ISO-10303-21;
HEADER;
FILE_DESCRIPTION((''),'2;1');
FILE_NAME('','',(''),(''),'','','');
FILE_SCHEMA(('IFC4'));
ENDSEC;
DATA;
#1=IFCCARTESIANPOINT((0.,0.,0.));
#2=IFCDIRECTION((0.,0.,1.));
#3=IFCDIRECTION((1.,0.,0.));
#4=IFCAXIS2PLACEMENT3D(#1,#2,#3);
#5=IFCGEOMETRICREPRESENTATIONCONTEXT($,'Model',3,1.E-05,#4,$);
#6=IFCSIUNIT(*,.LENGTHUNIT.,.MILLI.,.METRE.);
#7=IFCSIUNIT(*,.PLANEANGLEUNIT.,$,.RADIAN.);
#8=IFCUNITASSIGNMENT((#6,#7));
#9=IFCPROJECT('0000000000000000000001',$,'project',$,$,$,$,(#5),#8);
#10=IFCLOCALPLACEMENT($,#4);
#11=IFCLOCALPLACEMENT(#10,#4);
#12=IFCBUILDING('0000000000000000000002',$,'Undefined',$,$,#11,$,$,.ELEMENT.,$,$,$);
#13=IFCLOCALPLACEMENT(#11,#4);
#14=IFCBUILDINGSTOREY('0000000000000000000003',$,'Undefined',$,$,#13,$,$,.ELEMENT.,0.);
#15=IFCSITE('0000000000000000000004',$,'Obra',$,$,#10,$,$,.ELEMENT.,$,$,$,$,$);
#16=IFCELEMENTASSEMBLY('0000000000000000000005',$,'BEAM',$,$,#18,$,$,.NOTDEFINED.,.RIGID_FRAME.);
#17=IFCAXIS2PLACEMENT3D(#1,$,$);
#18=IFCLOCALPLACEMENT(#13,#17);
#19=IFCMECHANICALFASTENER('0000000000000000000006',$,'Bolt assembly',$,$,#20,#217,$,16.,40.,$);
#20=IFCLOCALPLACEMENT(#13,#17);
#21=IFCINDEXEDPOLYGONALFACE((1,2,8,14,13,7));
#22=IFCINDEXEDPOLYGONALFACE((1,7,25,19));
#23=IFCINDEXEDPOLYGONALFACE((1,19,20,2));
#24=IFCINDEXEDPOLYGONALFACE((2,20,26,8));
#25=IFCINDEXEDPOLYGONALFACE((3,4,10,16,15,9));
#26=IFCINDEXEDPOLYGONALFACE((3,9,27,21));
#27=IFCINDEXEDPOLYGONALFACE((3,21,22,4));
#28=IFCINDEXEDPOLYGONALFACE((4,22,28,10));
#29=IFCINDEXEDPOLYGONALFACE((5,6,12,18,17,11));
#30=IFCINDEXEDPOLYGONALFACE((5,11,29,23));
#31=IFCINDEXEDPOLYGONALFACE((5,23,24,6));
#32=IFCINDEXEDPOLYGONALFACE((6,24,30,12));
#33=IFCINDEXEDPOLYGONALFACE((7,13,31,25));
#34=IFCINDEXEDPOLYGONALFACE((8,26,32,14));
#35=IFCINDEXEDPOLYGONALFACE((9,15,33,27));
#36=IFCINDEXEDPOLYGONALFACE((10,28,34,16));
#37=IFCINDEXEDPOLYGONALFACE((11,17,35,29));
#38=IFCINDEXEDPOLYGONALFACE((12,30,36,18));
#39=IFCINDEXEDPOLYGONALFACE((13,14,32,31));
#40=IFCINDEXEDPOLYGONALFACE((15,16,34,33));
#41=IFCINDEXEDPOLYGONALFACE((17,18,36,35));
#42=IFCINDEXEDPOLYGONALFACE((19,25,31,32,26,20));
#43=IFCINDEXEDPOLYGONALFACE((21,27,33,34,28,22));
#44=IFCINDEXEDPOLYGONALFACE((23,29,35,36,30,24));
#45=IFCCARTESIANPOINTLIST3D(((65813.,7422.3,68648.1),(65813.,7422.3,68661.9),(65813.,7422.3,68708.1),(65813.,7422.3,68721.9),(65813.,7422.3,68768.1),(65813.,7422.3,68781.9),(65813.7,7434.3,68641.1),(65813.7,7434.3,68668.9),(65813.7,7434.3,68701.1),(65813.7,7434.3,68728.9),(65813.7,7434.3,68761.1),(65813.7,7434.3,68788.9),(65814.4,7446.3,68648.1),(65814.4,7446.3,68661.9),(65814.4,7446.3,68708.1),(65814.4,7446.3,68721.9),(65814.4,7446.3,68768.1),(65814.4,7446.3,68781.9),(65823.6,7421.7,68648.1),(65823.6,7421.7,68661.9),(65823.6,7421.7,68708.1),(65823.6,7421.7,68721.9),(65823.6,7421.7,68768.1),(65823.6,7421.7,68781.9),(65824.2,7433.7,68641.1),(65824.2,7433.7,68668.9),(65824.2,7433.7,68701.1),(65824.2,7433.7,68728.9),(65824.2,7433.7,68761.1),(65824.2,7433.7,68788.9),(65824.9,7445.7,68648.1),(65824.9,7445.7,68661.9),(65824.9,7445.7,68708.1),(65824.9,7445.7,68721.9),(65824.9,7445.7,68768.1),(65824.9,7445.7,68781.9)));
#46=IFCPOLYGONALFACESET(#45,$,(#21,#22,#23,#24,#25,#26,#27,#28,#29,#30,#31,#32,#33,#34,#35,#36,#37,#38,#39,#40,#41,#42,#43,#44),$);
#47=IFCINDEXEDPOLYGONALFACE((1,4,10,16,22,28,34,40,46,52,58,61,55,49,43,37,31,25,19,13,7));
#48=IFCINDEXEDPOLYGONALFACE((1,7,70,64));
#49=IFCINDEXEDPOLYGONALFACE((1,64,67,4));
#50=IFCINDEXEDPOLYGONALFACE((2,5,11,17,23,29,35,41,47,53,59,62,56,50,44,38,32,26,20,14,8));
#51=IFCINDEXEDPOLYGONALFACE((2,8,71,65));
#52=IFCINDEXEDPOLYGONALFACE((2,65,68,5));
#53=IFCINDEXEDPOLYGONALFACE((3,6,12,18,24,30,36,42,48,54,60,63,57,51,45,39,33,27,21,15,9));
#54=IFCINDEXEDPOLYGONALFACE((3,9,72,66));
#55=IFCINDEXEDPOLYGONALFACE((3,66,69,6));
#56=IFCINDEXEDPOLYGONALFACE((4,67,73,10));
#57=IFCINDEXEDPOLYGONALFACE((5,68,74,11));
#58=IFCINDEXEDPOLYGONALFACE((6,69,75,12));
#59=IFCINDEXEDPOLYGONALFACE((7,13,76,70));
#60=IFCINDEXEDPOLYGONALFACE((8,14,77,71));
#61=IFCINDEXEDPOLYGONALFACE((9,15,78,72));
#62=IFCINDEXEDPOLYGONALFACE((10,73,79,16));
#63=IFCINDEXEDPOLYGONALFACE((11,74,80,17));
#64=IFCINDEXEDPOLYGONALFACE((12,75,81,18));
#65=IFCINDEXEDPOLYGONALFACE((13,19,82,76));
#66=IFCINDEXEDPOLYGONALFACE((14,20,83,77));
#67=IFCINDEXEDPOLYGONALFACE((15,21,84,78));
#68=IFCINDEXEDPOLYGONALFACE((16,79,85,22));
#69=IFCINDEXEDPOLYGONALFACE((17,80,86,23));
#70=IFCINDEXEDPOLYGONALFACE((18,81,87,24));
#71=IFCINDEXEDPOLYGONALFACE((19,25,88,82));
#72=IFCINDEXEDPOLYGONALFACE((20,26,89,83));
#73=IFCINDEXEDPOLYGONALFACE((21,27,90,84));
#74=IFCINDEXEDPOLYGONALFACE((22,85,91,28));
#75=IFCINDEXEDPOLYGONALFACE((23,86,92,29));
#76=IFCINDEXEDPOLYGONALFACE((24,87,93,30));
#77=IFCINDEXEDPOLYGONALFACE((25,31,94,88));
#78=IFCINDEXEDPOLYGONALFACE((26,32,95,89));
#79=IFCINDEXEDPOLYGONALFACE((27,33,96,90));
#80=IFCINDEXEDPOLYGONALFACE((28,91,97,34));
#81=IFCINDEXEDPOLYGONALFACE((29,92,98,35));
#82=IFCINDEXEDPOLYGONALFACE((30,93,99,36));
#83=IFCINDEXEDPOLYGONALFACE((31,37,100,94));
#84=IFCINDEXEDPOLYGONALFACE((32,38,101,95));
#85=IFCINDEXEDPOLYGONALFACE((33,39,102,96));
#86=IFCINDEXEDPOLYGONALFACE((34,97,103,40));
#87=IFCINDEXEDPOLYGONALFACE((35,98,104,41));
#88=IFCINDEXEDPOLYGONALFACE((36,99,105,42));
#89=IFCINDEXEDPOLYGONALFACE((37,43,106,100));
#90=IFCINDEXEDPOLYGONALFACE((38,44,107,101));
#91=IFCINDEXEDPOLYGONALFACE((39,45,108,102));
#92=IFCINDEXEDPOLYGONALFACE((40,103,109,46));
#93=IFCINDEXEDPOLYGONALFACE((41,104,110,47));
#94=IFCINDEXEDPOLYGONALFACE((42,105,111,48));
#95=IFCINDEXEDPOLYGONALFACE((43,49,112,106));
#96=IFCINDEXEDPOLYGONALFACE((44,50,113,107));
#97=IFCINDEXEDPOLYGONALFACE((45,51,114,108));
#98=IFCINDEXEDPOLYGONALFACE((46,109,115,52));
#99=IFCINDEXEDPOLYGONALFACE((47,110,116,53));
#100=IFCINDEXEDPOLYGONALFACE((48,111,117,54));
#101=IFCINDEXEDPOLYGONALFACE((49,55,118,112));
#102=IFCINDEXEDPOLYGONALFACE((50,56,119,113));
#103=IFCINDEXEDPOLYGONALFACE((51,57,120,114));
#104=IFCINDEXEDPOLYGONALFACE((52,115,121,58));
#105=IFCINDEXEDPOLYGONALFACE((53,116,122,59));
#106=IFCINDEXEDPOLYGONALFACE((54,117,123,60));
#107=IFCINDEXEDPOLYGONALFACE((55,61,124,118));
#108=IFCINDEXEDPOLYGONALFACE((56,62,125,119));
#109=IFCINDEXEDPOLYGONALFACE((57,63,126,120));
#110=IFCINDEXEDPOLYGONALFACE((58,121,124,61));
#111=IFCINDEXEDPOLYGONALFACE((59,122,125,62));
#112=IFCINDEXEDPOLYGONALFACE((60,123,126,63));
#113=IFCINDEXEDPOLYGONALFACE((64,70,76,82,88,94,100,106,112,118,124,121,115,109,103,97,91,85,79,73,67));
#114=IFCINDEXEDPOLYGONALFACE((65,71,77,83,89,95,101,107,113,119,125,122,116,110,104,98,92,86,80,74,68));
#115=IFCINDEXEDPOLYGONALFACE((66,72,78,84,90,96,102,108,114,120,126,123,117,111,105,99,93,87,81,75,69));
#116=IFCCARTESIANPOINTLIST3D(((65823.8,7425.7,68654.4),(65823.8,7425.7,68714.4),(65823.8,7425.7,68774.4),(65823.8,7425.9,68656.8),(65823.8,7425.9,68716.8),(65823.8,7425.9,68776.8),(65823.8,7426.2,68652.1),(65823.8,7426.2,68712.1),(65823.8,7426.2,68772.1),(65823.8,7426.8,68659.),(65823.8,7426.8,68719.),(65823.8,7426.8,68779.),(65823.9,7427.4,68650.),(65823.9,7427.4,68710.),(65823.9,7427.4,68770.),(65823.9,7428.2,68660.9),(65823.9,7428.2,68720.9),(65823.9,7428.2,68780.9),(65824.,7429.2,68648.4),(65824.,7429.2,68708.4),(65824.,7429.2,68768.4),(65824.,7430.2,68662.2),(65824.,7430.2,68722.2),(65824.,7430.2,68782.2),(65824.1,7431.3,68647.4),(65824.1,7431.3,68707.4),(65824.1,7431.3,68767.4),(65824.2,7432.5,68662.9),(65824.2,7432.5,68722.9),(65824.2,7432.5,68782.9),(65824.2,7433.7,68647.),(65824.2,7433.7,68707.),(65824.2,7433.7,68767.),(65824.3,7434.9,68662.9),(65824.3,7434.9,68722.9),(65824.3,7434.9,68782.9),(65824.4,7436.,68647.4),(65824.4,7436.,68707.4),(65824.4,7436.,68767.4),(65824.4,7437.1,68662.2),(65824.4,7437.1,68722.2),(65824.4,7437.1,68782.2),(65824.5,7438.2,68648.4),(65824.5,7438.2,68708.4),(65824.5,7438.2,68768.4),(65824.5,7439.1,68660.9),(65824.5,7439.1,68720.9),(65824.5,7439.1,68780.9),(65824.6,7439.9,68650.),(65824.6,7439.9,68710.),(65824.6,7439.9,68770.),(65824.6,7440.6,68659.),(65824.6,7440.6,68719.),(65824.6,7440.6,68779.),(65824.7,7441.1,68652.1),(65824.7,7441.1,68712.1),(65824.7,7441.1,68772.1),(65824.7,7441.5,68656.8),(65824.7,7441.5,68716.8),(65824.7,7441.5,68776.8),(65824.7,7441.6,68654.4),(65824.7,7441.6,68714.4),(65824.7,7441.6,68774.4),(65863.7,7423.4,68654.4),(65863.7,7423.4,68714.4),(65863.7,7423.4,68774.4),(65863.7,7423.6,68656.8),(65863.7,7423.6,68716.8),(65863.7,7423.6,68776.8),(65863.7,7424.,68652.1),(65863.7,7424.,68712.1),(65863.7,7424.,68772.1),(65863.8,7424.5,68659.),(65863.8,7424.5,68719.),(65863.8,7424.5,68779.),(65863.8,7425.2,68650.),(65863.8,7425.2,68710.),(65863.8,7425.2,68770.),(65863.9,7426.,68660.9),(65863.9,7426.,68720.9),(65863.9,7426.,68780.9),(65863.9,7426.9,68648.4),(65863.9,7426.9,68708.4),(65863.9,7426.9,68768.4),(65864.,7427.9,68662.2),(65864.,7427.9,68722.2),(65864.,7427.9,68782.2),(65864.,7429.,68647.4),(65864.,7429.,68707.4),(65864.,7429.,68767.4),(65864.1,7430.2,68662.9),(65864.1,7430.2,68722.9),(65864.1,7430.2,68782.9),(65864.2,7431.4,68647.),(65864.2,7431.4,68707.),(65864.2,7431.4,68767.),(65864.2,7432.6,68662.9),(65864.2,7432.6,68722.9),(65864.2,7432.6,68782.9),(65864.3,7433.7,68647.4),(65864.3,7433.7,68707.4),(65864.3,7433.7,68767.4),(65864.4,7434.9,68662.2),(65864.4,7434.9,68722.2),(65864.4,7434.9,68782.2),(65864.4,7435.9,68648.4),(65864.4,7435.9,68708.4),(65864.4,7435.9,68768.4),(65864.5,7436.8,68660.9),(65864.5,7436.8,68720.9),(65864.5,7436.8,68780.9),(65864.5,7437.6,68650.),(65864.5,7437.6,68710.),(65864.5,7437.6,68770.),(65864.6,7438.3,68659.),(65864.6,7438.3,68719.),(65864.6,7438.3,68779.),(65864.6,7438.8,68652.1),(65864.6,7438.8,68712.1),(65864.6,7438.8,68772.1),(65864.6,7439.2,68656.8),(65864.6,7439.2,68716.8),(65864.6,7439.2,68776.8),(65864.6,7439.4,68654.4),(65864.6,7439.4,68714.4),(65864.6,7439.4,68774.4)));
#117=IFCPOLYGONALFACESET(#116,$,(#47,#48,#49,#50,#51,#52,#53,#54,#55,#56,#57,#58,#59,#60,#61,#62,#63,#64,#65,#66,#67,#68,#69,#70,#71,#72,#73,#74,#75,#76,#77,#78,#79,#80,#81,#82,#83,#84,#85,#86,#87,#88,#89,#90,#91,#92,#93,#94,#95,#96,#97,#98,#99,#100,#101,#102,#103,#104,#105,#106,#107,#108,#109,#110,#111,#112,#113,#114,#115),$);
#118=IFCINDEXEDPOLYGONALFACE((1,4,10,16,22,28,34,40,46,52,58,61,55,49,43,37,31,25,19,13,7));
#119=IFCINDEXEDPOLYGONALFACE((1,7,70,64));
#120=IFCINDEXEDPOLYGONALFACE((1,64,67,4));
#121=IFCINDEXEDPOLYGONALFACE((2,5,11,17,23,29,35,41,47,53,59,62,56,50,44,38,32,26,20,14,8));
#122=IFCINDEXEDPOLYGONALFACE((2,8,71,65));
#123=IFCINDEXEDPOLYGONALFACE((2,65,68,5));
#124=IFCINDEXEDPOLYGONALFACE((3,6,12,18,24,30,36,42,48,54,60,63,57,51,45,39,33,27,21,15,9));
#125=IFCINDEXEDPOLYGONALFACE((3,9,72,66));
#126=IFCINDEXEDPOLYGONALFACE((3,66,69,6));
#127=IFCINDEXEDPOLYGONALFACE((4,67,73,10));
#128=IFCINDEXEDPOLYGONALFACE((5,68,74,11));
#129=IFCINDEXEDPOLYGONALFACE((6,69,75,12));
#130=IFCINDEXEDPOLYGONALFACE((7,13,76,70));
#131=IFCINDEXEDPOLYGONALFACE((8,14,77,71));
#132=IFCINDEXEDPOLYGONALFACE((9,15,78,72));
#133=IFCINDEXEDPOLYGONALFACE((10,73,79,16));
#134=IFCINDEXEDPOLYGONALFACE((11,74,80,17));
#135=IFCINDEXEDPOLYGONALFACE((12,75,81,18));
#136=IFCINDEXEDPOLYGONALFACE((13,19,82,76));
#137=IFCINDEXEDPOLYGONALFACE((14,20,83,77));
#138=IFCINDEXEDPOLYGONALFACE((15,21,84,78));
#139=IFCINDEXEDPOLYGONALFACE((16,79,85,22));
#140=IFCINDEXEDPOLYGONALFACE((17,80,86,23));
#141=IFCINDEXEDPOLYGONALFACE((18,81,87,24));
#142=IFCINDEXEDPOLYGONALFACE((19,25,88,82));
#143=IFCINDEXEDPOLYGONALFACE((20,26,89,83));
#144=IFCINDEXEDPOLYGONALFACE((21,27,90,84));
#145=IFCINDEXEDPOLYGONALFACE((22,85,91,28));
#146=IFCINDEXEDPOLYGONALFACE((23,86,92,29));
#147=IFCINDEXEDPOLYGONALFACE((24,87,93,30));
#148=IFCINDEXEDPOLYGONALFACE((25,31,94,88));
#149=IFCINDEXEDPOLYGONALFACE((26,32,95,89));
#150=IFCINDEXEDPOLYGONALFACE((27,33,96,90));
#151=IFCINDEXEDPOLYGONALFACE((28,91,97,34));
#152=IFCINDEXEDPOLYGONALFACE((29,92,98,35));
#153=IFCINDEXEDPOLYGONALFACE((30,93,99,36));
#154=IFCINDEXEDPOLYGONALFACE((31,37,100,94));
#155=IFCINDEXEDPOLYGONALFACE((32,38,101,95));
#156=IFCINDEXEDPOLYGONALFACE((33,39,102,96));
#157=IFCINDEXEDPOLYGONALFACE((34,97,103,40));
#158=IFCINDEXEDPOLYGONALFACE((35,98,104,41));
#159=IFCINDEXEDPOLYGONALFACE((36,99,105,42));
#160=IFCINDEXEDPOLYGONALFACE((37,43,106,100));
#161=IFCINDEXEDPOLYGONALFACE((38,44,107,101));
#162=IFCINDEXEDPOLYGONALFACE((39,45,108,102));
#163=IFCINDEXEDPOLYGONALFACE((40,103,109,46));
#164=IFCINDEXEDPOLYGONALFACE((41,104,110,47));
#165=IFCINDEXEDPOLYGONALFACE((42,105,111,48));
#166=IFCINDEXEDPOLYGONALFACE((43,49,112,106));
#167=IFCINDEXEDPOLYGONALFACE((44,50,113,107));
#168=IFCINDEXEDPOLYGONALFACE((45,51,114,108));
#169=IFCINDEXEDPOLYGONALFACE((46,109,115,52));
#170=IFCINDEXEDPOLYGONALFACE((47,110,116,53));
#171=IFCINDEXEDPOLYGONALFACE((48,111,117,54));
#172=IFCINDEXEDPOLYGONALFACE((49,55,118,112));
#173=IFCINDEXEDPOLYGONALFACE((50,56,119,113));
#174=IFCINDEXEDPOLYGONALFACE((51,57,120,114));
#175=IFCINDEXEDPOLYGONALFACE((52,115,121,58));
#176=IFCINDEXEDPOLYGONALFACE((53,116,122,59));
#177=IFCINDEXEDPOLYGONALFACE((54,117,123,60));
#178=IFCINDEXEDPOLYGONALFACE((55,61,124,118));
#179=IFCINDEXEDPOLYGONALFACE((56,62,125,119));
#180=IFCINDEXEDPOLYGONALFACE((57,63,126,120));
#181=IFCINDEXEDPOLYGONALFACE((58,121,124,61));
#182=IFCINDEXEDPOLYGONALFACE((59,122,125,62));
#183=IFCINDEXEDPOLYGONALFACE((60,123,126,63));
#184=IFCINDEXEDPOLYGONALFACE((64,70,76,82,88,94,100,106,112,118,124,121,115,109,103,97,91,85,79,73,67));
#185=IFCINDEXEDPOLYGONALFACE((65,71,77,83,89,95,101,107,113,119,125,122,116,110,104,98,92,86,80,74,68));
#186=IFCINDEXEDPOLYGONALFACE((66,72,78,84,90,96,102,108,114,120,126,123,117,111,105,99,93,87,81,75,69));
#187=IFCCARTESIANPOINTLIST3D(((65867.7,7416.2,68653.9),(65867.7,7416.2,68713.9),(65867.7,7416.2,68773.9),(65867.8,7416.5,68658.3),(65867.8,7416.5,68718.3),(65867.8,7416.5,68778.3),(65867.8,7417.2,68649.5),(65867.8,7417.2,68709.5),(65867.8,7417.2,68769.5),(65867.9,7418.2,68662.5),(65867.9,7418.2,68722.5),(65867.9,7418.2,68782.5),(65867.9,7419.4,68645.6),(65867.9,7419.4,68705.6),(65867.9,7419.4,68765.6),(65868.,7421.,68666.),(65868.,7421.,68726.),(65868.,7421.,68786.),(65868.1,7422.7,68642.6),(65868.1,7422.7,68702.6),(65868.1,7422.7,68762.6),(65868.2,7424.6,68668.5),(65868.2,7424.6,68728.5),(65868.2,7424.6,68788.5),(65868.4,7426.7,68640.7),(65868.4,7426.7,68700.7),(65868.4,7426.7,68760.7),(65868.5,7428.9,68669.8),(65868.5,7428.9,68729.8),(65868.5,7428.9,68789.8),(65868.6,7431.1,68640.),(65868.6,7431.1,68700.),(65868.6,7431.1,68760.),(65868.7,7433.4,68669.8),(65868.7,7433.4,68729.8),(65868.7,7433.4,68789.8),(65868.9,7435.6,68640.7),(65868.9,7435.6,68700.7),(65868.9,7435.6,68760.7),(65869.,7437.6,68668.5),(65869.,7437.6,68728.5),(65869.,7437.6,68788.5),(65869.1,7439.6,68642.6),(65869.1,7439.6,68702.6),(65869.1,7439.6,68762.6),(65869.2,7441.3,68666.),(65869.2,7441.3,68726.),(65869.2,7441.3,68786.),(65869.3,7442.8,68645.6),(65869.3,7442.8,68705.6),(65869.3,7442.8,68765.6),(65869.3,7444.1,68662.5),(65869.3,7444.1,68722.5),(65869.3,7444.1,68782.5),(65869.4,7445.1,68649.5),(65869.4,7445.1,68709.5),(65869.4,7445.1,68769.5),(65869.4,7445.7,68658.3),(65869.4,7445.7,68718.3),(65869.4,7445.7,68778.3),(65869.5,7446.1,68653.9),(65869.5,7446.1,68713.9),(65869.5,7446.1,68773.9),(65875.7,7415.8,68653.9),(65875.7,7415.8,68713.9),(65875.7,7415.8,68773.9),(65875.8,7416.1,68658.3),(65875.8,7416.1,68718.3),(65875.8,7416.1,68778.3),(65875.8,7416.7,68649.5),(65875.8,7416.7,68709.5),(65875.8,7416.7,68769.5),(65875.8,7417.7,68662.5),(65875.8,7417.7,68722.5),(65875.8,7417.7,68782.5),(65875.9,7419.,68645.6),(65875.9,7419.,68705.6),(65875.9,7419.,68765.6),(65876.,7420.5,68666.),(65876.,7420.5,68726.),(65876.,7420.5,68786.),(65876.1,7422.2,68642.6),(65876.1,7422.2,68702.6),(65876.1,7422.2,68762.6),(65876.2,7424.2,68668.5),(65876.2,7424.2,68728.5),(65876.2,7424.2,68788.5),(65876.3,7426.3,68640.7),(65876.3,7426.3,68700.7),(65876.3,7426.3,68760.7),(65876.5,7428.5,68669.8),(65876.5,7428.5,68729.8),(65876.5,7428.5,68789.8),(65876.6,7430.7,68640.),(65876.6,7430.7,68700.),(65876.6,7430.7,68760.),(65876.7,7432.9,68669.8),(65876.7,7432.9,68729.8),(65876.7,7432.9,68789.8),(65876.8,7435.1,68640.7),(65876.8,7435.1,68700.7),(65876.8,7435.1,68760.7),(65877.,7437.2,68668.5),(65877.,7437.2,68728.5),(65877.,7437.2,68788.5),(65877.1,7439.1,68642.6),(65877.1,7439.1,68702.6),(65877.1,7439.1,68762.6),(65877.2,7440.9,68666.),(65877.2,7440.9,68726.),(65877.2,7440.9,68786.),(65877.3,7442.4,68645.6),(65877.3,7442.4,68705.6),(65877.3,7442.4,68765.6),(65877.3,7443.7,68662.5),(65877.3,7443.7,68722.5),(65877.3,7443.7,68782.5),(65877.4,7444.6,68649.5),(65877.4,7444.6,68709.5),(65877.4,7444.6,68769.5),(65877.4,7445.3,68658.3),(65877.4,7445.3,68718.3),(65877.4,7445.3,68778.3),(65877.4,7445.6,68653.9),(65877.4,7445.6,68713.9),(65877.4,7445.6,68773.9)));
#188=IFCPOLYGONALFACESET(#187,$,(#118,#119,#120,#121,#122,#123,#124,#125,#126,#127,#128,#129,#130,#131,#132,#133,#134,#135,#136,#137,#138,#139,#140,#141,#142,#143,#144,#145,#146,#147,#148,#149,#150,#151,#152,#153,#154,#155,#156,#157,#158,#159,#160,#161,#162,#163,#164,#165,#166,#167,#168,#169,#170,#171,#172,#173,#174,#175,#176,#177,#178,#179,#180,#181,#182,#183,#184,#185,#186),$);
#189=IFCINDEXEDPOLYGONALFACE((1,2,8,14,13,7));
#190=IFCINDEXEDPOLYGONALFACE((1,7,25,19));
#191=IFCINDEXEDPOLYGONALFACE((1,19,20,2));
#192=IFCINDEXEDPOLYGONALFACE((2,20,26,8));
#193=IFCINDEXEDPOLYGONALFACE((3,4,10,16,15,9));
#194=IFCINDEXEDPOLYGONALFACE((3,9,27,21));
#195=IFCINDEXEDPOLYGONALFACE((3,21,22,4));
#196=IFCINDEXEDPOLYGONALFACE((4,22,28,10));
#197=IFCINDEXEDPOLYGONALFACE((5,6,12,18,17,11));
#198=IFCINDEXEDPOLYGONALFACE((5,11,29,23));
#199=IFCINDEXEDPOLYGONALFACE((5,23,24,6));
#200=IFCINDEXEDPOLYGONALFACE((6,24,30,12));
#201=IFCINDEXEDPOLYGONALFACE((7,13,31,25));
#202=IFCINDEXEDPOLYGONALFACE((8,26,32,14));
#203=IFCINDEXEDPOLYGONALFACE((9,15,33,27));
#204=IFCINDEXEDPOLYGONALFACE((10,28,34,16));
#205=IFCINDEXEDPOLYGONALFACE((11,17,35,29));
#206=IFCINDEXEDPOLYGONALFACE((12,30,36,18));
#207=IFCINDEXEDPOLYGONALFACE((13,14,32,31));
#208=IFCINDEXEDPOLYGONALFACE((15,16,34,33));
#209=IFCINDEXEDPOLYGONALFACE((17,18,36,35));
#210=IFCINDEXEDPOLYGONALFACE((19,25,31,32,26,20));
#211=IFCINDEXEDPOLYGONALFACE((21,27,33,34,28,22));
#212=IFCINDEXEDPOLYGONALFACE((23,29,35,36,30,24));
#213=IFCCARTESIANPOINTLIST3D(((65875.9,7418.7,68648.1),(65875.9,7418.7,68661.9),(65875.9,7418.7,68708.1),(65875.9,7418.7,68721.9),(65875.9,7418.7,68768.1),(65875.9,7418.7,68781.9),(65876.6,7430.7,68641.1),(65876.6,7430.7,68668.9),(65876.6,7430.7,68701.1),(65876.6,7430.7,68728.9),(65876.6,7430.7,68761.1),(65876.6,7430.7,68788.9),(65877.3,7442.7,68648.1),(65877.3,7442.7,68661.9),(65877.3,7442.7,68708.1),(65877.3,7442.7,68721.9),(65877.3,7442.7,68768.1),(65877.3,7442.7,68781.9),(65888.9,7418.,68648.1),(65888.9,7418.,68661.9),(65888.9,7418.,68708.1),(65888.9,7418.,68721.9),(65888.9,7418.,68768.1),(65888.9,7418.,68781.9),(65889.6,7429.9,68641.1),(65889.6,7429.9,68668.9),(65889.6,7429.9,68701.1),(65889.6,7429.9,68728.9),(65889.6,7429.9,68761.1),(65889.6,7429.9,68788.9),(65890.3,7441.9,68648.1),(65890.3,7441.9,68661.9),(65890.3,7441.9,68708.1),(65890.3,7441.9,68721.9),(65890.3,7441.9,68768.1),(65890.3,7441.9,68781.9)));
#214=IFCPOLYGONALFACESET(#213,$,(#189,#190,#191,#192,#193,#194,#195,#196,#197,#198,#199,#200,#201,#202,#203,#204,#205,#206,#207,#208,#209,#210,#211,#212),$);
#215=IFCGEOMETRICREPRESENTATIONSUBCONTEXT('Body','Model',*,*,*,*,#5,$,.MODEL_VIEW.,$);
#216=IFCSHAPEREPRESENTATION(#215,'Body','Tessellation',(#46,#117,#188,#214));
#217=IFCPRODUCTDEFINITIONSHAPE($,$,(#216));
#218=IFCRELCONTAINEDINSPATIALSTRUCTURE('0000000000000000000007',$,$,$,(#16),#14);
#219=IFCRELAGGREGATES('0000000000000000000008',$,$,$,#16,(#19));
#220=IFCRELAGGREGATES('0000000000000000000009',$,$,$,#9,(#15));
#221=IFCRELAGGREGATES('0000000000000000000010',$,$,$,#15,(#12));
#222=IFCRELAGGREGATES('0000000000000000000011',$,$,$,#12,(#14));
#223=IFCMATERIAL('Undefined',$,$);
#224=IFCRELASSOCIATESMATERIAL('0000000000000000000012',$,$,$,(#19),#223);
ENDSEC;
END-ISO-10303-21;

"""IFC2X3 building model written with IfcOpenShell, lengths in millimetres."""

from ifc_helpers import new_model, si_unit, frame, origin_with_axes, origin_2d_with_axis, place, context, subcontext, project, spatial, polyline, circle, outline, extrude, source, transform, mapped, material, element, aggregate, save


model = new_model("IFC2X3")

# Units and contexts
model_context = context("Model", 3, precision=1e-05, world=origin_with_axes())
body_context = subcontext(model_context, "Body", "Model", "MODEL_VIEW")
ifc_project = project(units=[si_unit("LENGTHUNIT", "METRE", prefix="MILLI"), si_unit("PLANEANGLEUNIT", "RADIAN")], contexts=[model_context])

# Site, building, storey
site_placement = place(None, origin_with_axes())
site = spatial("IfcSite", under=ifc_project, at=site_placement, Name="Obra", CompositionType="ELEMENT")
building_placement = place(site_placement, origin_with_axes())
building = spatial("IfcBuilding", under=site, at=building_placement, Name="Undefined", CompositionType="ELEMENT")
storey_placement = place(building_placement, origin_with_axes())
storey = spatial("IfcBuildingStorey", under=building, at=storey_placement, Name="Undefined", CompositionType="ELEMENT", Elevation=0.0)

# Element assembly, mechanical fastener
ifc_material_1 = material(Name="Undefined")
shared_shape_1 = source(origin_with_axes(), body_context, "Body", "SweptSolid", [
    extrude(outline(polyline([(13.9, 0.0), (6.9, 12.0), (-6.9, 12.0), (-13.9, 0.0), (-6.9, -12.0), (6.9, -12.0), (13.9, 0.0)])), frame((0.0, -19.7, 0.0), z_axis=(0.0, 1.0, 0.0), x_axis=(1.0, 0.0, 0.0)), (0.0, 0.0, 1.0), 10.6),
    extrude(circle(Radius=8.0, at=origin_2d_with_axis()), frame((0.0, -9.1, 0.0), z_axis=(0.0, 1.0, 0.0), x_axis=(1.0, 0.0, 0.0)), (0.0, 0.0, 1.0), 40.0),
    extrude(circle(Radius=15.0, at=origin_2d_with_axis()), frame((0.0, 35.3, 0.0), z_axis=(0.0, 1.0, 0.0), x_axis=(1.0, 0.0, 0.0)), (0.0, 0.0, 1.0), 8.0),
    extrude(outline(polyline([(13.9, 0.0), (6.9, 12.0), (-6.9, 12.0), (-13.9, 0.0), (-6.9, -12.0), (6.9, -12.0), (13.9, 0.0)])), frame((0.0, 43.3, 0.0), z_axis=(0.0, 1.0, 0.0), x_axis=(1.0, 0.0, 0.0)), (0.0, 0.0, 1.0), 13.0),
])
assembly_1_placement = place(storey_placement, origin_with_axes())
assembly_1 = element("IfcElementAssembly", 1, at=assembly_1_placement, inside=storey, Name="BEAM", AssemblyPlace="NOTDEFINED", PredefinedType="RIGID_FRAME")
mechanical_fastener_1_placement = place(assembly_1_placement, frame((65836.2, 7483.1, 68835.0), z_axis=(-0.05711, -0.998368, 0.0), x_axis=(0.0, 0.0, -1.0)))
mechanical_fastener_1 = element("IfcMechanicalFastener", 2, at=mechanical_fastener_1_placement, material=ifc_material_1, Name="Bolt assembly", NominalDiameter=16.0, NominalLength=40.0, context=body_context, shape_type="MappedRepresentation", body=[
    mapped(shared_shape_1, transform((60.0, 0.0, 50.0))),
    mapped(shared_shape_1, transform((120.0, 0.0, 50.0))),
    mapped(shared_shape_1, transform((180.0, 0.0, 50.0))),
])
aggregate(assembly_1, [mechanical_fastener_1])

save(model, "model.ifc")
